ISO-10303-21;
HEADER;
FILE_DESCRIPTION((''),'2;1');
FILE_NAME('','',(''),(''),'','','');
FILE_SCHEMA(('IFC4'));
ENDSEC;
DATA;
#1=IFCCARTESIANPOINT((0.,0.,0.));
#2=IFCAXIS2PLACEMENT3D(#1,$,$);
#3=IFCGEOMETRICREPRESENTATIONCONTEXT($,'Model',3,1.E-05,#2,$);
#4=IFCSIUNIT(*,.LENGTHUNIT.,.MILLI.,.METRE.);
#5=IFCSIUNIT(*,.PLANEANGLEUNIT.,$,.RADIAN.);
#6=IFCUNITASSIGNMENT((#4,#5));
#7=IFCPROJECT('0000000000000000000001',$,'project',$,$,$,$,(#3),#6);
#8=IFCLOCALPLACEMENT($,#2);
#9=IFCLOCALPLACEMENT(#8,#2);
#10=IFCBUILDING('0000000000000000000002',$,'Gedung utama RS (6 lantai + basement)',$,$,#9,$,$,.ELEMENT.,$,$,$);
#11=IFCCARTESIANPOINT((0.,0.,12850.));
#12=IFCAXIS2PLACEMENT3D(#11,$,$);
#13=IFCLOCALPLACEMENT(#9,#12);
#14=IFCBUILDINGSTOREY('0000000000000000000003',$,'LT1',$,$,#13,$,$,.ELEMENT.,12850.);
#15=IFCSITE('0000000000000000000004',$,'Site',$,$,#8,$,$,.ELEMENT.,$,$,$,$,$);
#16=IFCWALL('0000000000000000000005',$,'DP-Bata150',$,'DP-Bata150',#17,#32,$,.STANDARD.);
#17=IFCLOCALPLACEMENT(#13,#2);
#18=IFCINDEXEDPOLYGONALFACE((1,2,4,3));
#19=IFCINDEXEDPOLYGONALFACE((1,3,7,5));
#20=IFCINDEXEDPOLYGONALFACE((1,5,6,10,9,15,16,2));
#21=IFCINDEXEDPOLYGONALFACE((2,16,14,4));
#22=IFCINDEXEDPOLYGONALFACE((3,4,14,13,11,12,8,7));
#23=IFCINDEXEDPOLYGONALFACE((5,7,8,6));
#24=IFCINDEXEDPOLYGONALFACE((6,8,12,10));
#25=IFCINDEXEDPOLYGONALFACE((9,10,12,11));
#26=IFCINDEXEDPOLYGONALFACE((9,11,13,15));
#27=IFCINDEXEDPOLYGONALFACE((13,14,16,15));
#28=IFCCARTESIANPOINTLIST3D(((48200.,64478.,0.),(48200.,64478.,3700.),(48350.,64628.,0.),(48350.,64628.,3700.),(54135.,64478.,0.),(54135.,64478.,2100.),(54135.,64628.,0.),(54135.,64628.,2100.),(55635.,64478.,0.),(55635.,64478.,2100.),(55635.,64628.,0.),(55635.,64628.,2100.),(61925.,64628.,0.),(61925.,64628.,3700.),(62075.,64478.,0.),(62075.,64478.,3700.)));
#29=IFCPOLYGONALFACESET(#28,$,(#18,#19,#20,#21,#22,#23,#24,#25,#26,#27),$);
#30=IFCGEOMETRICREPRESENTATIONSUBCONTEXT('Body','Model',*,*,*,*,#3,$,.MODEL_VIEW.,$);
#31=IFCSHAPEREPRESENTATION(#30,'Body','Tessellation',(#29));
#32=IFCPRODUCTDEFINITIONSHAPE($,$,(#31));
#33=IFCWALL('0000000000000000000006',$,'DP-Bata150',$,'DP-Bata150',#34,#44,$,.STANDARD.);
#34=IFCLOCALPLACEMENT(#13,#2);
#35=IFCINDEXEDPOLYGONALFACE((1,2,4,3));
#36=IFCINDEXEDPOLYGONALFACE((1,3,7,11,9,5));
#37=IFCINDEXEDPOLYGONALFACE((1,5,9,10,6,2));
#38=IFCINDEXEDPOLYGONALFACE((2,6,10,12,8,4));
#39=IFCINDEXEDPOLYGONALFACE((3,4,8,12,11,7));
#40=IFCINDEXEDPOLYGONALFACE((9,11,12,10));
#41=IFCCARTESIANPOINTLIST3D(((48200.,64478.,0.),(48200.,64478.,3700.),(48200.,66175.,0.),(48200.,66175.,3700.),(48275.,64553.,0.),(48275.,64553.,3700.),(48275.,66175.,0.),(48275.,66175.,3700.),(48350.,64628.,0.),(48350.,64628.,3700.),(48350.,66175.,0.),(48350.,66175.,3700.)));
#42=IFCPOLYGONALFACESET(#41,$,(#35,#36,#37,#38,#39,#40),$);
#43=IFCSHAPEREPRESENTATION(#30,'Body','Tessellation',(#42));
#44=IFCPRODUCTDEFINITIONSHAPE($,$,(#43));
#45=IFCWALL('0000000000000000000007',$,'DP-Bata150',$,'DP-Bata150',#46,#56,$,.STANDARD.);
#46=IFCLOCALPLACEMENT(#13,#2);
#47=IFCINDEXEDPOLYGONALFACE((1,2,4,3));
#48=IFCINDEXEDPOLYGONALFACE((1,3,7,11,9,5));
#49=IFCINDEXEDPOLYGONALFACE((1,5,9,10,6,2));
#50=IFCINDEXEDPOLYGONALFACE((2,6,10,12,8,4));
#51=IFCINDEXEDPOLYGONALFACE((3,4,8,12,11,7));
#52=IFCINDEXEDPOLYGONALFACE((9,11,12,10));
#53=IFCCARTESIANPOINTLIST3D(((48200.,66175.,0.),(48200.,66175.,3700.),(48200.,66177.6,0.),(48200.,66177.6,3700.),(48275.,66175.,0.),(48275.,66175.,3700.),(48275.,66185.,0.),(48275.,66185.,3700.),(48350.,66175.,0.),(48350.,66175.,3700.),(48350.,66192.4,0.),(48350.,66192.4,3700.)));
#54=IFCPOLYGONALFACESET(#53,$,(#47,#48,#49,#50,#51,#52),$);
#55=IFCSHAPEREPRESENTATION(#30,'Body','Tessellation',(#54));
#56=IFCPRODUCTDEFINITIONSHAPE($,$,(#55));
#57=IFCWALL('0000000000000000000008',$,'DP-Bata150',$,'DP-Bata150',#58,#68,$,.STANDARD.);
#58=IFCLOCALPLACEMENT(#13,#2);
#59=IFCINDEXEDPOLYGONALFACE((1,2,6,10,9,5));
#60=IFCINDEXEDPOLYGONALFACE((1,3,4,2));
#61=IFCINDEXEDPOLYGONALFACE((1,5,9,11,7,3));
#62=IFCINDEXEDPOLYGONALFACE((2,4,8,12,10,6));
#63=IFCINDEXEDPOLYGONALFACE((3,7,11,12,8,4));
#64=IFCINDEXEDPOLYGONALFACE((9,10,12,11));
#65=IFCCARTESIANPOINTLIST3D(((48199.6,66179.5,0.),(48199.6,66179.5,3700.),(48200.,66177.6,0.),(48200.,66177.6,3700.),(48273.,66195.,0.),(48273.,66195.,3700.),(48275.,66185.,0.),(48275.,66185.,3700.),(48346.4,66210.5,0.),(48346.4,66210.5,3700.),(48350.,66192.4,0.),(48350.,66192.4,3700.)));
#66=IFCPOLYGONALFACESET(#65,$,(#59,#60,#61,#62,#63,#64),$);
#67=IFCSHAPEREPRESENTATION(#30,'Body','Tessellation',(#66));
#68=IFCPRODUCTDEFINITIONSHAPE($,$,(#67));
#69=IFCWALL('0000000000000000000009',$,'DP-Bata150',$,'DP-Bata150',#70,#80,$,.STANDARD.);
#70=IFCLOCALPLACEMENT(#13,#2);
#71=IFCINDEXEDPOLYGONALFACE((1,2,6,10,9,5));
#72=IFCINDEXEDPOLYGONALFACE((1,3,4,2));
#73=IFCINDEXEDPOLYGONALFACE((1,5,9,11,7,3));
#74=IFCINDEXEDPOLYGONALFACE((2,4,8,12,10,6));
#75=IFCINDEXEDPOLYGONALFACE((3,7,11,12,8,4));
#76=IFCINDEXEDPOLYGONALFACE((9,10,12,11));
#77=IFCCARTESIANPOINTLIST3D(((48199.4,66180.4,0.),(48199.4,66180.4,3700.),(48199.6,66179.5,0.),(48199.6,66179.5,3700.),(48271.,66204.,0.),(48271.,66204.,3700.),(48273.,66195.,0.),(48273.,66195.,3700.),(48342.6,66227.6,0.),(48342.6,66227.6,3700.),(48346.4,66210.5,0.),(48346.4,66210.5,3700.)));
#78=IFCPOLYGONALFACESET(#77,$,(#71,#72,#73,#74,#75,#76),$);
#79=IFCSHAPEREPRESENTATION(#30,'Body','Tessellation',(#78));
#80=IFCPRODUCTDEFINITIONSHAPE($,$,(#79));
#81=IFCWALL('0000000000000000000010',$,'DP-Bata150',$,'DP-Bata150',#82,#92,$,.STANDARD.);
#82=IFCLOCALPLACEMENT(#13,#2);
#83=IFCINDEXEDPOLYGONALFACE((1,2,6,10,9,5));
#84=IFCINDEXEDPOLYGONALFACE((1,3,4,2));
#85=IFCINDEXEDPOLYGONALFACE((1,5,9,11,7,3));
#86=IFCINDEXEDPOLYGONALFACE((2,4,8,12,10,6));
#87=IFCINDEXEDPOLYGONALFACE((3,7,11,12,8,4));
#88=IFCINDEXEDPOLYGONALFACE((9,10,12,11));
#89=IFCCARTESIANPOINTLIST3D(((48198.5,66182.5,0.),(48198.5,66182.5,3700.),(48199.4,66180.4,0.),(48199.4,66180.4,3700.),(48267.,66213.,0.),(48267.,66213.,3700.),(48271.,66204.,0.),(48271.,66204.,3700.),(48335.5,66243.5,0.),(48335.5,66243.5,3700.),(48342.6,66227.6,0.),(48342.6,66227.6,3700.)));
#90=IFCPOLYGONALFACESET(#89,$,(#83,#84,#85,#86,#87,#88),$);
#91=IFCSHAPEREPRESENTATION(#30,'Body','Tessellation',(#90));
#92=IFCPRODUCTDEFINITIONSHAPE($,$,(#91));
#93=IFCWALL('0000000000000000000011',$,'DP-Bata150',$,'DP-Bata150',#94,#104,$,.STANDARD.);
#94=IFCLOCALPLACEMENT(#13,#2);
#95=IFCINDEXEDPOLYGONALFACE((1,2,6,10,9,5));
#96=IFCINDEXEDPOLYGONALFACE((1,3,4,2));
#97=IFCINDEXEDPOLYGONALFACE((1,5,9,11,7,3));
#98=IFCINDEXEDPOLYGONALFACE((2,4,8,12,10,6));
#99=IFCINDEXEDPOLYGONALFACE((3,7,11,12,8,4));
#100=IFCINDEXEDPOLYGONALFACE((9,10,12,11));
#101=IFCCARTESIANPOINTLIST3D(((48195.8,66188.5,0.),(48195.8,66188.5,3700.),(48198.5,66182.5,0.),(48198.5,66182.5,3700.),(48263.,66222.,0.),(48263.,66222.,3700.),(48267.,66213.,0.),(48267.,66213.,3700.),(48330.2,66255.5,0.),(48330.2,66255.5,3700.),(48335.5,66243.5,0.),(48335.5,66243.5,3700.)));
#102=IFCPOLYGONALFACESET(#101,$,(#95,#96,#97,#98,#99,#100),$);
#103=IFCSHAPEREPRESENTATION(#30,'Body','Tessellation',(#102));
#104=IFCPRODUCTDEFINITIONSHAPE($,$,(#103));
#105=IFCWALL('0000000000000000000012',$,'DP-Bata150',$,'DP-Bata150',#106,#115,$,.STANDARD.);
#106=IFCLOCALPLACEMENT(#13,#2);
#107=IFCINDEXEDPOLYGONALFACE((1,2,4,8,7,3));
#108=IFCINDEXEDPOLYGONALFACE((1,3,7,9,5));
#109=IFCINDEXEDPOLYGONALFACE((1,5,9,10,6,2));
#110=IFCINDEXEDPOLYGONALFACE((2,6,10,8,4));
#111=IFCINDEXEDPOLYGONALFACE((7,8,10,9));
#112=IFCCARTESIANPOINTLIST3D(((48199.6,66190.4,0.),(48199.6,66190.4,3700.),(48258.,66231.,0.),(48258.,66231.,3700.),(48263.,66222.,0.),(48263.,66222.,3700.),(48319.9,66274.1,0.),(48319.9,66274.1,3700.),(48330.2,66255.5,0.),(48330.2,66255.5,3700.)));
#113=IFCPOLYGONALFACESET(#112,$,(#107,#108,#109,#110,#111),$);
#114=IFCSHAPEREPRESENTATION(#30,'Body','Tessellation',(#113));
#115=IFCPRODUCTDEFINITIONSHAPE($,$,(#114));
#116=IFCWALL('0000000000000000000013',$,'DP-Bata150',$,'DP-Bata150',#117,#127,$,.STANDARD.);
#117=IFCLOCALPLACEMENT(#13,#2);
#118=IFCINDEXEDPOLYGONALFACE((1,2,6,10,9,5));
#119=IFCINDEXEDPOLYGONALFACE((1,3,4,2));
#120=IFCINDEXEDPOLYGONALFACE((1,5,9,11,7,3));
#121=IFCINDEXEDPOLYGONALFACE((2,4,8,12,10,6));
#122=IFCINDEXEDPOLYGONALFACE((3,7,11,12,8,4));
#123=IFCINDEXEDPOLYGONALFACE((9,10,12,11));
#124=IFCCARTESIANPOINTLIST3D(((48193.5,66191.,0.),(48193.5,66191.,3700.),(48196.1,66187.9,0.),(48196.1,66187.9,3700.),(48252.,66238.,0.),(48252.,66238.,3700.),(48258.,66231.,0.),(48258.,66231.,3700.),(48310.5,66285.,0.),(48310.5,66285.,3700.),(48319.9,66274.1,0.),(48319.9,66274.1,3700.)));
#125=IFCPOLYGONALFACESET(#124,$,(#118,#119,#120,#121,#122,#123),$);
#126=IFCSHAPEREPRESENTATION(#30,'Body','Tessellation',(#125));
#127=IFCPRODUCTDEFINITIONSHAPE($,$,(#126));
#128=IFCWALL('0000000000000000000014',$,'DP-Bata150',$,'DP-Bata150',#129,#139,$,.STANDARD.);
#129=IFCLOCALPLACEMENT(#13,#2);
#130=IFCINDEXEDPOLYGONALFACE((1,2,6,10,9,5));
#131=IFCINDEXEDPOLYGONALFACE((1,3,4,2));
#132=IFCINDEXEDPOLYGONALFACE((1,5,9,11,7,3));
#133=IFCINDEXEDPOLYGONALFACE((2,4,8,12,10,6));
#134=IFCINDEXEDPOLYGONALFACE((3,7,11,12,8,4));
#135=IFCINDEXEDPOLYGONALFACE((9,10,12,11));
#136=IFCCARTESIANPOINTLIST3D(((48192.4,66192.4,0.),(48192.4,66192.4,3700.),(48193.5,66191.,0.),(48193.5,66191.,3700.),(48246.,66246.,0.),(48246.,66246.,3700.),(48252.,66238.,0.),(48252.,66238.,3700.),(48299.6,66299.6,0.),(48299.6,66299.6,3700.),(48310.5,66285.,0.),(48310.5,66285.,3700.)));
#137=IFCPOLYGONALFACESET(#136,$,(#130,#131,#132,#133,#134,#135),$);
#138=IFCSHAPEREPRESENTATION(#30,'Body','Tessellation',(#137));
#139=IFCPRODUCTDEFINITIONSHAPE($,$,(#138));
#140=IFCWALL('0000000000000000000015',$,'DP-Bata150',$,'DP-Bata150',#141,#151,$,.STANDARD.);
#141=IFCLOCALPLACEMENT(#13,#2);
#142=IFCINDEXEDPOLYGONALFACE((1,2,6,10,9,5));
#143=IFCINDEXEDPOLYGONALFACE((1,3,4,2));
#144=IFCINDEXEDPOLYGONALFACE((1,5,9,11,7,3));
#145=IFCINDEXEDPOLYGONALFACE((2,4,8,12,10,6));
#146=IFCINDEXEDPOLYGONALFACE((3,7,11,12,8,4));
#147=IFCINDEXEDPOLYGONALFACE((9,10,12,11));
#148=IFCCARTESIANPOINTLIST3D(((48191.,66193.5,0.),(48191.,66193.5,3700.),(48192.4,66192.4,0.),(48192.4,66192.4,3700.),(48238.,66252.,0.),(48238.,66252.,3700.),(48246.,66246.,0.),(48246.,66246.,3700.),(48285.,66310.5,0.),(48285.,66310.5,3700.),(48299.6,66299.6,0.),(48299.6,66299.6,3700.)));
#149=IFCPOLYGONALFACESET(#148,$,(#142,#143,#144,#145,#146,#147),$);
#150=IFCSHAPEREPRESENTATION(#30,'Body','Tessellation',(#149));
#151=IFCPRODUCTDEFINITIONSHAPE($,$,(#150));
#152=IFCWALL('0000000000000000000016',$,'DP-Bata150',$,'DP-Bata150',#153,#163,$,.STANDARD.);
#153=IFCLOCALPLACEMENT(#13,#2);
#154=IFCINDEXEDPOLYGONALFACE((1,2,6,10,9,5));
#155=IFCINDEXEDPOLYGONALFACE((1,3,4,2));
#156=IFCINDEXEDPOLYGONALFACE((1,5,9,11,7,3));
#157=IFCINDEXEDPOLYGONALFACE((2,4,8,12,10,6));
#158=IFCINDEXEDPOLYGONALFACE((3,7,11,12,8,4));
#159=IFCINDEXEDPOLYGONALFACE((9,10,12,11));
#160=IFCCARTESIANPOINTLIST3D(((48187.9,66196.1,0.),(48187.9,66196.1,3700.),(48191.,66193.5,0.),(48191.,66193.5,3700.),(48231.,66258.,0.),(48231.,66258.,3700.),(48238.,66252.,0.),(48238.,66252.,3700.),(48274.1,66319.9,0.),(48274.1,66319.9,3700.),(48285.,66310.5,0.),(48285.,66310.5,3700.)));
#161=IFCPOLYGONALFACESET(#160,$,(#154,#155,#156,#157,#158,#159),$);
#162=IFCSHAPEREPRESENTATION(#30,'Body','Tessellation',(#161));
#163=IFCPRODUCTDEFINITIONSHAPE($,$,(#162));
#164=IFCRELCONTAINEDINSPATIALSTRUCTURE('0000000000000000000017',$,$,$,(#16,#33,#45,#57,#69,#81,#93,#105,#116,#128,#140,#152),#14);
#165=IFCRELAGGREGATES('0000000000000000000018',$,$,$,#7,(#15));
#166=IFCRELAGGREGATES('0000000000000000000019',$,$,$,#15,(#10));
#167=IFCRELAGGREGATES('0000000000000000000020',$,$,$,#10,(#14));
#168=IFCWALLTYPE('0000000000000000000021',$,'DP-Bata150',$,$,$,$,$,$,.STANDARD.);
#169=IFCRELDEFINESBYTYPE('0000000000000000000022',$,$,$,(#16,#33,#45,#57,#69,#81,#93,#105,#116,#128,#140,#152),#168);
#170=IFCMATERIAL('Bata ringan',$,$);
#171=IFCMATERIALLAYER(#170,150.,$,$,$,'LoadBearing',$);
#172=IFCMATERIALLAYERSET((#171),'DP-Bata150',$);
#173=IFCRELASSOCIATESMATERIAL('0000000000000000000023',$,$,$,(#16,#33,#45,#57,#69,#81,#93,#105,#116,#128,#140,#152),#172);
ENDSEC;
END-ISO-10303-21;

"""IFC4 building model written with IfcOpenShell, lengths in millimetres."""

from ifc_helpers import new_model, si_unit, frame, frame_2d, origin, place, context, subcontext, project, spatial, polyline, rectangle, outline, extrude, material, layer, layer_set, layer_usage, type_object, element, save


model = new_model("IFC4")

# Units and contexts
model_context = context("Model", 3, precision=1e-05, world=origin())
body_context = subcontext(model_context, "Body", "Model", "MODEL_VIEW")
ifc_project = project(units=[si_unit("LENGTHUNIT", "METRE", prefix="MILLI"), si_unit("PLANEANGLEUNIT", "RADIAN")], contexts=[model_context])

# Site, building, storey
site_placement = place(None, origin())
site = spatial("IfcSite", under=ifc_project, at=site_placement, Name="Site", CompositionType="ELEMENT")
building_placement = place(site_placement, origin())
building = spatial("IfcBuilding", under=site, at=building_placement, Name="Gedung utama RS (6 lantai + basement)", CompositionType="ELEMENT")
storey_placement = place(building_placement, frame((0.0, 0.0, 12850.0)))
storey = spatial("IfcBuildingStorey", under=building, at=storey_placement, Name="LT1", CompositionType="ELEMENT", Elevation=12850.0)

# Wall, opening
ifc_material = material(Name="Bata ringan")
ifc_layer = layer(ifc_material, 150.0, Category="LoadBearing")
ifc_layer_set = layer_set([ifc_layer], Name="DP-Bata150")
ifc_layer_usage = layer_usage(ifc_layer_set, "AXIS2", "NEGATIVE", 75.0)
wall_type = type_object("IfcWallType", Name="DP-Bata150", PredefinedType="STANDARD")
wall_1_placement = place(storey_placement, frame((62000.0, 64553.0, 0.0), z_axis=(0.0, 0.0, 1.0), x_axis=(-1.0, 0.0, 0.0)))
wall_1 = element("IfcWall", 1, at=wall_1_placement, inside=storey, type_object=wall_type, material=ifc_layer_usage, Name="DP-Bata150", ObjectType="DP-Bata150", PredefinedType="STANDARD", context=body_context, shape_type="SweptSolid", body=[
    extrude(outline(polyline([(75.0, -75.0), (0.0, 0.0), (-75.0, 75.0), (13800.0, 75.0), (13725.0, 0.0), (13650.0, -75.0), (75.0, -75.0)])), origin(), (0.0, 0.0, 1.0), 3700.0),
])
opening_1_placement = place(wall_1_placement, frame((6365.0, 0.0, 0.0), z_axis=(0.0, 0.0, 1.0), x_axis=(1.0, 0.0, 0.0)))
element("IfcOpeningElement", 2, at=opening_1_placement, cuts=wall_1, PredefinedType="OPENING", context=body_context, shape_type="SweptSolid", body=[
    extrude(rectangle(XDim=1500.0, YDim=170.0, at=frame_2d((750.0, 0.0))), origin(), (0.0, 0.0, 1.0), 2100.0),
])

# Walls
wall_2_placement = place(storey_placement, frame((48275.0, 64553.0, 0.0), z_axis=(0.0, 0.0, 1.0), x_axis=(0.0, 1.0, 0.0)))
element("IfcWall", 3, at=wall_2_placement, inside=storey, type_object=wall_type, material=ifc_layer_usage, Name="DP-Bata150", ObjectType="DP-Bata150", PredefinedType="STANDARD", context=body_context, shape_type="SweptSolid", body=[
    extrude(outline(polyline([(75.0, -75.0), (0.0, 0.0), (-75.0, 75.0), (1622.0, 75.0), (1622.0, 0.0), (1622.0, -75.0), (75.0, -75.0)])), origin(), (0.0, 0.0, 1.0), 3700.0),
])
wall_3_placement = place(storey_placement, frame((48275.0, 66175.0, 0.0), z_axis=(0.0, 0.0, 1.0), x_axis=(0.0, 1.0, 0.0)))
element("IfcWall", 4, at=wall_3_placement, inside=storey, type_object=wall_type, material=ifc_layer_usage, Name="DP-Bata150", ObjectType="DP-Bata150", PredefinedType="STANDARD", context=body_context, shape_type="SweptSolid", body=[
    extrude(outline(polyline([(0.0, -75.0), (0.0, 0.0), (0.0, 75.0), (2.6, 75.0), (10.0, 0.0), (17.4, -75.0), (0.0, -75.0)])), origin(), (0.0, 0.0, 1.0), 3700.0),
])
wall_4_placement = place(storey_placement, frame((48275.0, 66185.0, 0.0), z_axis=(0.0, 0.0, 1.0), x_axis=(-0.196116, 0.980581, 0.0)))
element("IfcWall", 5, at=wall_4_placement, inside=storey, type_object=wall_type, material=ifc_layer_usage, Name="DP-Bata150", ObjectType="DP-Bata150", PredefinedType="STANDARD", context=body_context, shape_type="SweptSolid", body=[
    extrude(outline(polyline([(-7.4, -75.0), (0.0, 0.0), (7.4, 75.0), (9.4, 75.0), (10.2, 0.0), (11.0, -75.0), (-7.4, -75.0)])), origin(), (0.0, 0.0, 1.0), 3700.0),
])
wall_5_placement = place(storey_placement, frame((48273.0, 66195.0, 0.0), z_axis=(0.0, 0.0, 1.0), x_axis=(-0.21693, 0.976187, 0.0)))
element("IfcWall", 6, at=wall_5_placement, inside=storey, type_object=wall_type, material=ifc_layer_usage, Name="DP-Bata150", ObjectType="DP-Bata150", PredefinedType="STANDARD", context=body_context, shape_type="SweptSolid", body=[
    extrude(outline(polyline([(-0.8, -75.0), (0.0, 0.0), (0.8, 75.0), (1.7, 75.0), (9.2, 0.0), (16.7, -75.0), (-0.8, -75.0)])), origin(), (0.0, 0.0, 1.0), 3700.0),
])
wall_6_placement = place(storey_placement, frame((48271.0, 66204.0, 0.0), z_axis=(0.0, 0.0, 1.0), x_axis=(-0.406138, 0.913812, 0.0)))
element("IfcWall", 7, at=wall_6_placement, inside=storey, type_object=wall_type, material=ifc_layer_usage, Name="DP-Bata150", ObjectType="DP-Bata150", PredefinedType="STANDARD", context=body_context, shape_type="SweptSolid", body=[
    extrude(outline(polyline([(-7.5, -75.0), (0.0, 0.0), (7.5, 75.0), (9.8, 75.0), (9.8, 0.0), (9.8, -75.0), (-7.5, -75.0)])), origin(), (0.0, 0.0, 1.0), 3700.0),
])
wall_7_placement = place(storey_placement, frame((48267.0, 66213.0, 0.0), z_axis=(0.0, 0.0, 1.0), x_axis=(-0.406138, 0.913812, 0.0)))
element("IfcWall", 8, at=wall_7_placement, inside=storey, type_object=wall_type, material=ifc_layer_usage, Name="DP-Bata150", ObjectType="DP-Bata150", PredefinedType="STANDARD", context=body_context, shape_type="SweptSolid", body=[
    extrude(outline(polyline([(0.0, -75.0), (0.0, 0.0), (0.0, 75.0), (6.5, 75.0), (9.8, 0.0), (13.2, -75.0), (0.0, -75.0)])), origin(), (0.0, 0.0, 1.0), 3700.0),
])
wall_8_placement = place(storey_placement, frame((48263.0, 66222.0, 0.0), z_axis=(0.0, 0.0, 1.0), x_axis=(-0.485643, 0.874157, 0.0)))
element("IfcWall", 9, at=wall_8_placement, inside=storey, type_object=wall_type, material=ifc_layer_usage, Name="DP-Bata150", ObjectType="DP-Bata150", PredefinedType="STANDARD", context=body_context, shape_type="SweptSolid", body=[
    extrude(outline(polyline([(-3.3, -75.0), (0.0, 0.0), (3.3, 75.0), (2.7, 75.0), (10.3, 0.0), (17.9, -75.0), (-3.3, -75.0)])), origin(), (0.0, 0.0, 1.0), 3700.0),
])
wall_9_placement = place(storey_placement, frame((48258.0, 66231.0, 0.0), z_axis=(0.0, 0.0, 1.0), x_axis=(-0.650791, 0.759257, 0.0)))
element("IfcWall", 10, at=wall_9_placement, inside=storey, type_object=wall_type, material=ifc_layer_usage, Name="DP-Bata150", ObjectType="DP-Bata150", PredefinedType="STANDARD", context=body_context, shape_type="SweptSolid", body=[
    extrude(outline(polyline([(-7.6, -75.0), (0.0, 0.0), (7.6, 75.0), (11.7, 75.0), (9.2, 0.0), (6.8, -75.0), (-7.6, -75.0)])), origin(), (0.0, 0.0, 1.0), 3700.0),
])
wall_10_placement = place(storey_placement, frame((48252.0, 66238.0, 0.0), z_axis=(0.0, 0.0, 1.0), x_axis=(-0.6, 0.8, 0.0)))
element("IfcWall", 11, at=wall_10_placement, inside=storey, type_object=wall_type, material=ifc_layer_usage, Name="DP-Bata150", ObjectType="DP-Bata150", PredefinedType="STANDARD", context=body_context, shape_type="SweptSolid", body=[
    extrude(outline(polyline([(2.4, -75.0), (0.0, 0.0), (-2.4, 75.0), (-0.7, 75.0), (10.0, 0.0), (20.7, -75.0), (2.4, -75.0)])), origin(), (0.0, 0.0, 1.0), 3700.0),
])
wall_11_placement = place(storey_placement, frame((48246.0, 66246.0, 0.0), z_axis=(0.0, 0.0, 1.0), x_axis=(-0.8, 0.6, 0.0)))
element("IfcWall", 12, at=wall_11_placement, inside=storey, type_object=wall_type, material=ifc_layer_usage, Name="DP-Bata150", ObjectType="DP-Bata150", PredefinedType="STANDARD", context=body_context, shape_type="SweptSolid", body=[
    extrude(outline(polyline([(-10.7, -75.0), (0.0, 0.0), (10.7, 75.0), (12.4, 75.0), (10.0, 0.0), (7.6, -75.0), (-10.7, -75.0)])), origin(), (0.0, 0.0, 1.0), 3700.0),
])
wall_12_placement = place(storey_placement, frame((48238.0, 66252.0, 0.0), z_axis=(0.0, 0.0, 1.0), x_axis=(-0.759257, 0.650791, 0.0)))
element("IfcWall", 13, at=wall_12_placement, inside=storey, type_object=wall_type, material=ifc_layer_usage, Name="DP-Bata150", ObjectType="DP-Bata150", PredefinedType="STANDARD", context=body_context, shape_type="SweptSolid", body=[
    extrude(outline(polyline([(2.4, -75.0), (0.0, 0.0), (-2.4, 75.0), (1.6, 75.0), (9.2, 0.0), (16.8, -75.0), (2.4, -75.0)])), origin(), (0.0, 0.0, 1.0), 3700.0),
])

save(model, "model.ifc")
